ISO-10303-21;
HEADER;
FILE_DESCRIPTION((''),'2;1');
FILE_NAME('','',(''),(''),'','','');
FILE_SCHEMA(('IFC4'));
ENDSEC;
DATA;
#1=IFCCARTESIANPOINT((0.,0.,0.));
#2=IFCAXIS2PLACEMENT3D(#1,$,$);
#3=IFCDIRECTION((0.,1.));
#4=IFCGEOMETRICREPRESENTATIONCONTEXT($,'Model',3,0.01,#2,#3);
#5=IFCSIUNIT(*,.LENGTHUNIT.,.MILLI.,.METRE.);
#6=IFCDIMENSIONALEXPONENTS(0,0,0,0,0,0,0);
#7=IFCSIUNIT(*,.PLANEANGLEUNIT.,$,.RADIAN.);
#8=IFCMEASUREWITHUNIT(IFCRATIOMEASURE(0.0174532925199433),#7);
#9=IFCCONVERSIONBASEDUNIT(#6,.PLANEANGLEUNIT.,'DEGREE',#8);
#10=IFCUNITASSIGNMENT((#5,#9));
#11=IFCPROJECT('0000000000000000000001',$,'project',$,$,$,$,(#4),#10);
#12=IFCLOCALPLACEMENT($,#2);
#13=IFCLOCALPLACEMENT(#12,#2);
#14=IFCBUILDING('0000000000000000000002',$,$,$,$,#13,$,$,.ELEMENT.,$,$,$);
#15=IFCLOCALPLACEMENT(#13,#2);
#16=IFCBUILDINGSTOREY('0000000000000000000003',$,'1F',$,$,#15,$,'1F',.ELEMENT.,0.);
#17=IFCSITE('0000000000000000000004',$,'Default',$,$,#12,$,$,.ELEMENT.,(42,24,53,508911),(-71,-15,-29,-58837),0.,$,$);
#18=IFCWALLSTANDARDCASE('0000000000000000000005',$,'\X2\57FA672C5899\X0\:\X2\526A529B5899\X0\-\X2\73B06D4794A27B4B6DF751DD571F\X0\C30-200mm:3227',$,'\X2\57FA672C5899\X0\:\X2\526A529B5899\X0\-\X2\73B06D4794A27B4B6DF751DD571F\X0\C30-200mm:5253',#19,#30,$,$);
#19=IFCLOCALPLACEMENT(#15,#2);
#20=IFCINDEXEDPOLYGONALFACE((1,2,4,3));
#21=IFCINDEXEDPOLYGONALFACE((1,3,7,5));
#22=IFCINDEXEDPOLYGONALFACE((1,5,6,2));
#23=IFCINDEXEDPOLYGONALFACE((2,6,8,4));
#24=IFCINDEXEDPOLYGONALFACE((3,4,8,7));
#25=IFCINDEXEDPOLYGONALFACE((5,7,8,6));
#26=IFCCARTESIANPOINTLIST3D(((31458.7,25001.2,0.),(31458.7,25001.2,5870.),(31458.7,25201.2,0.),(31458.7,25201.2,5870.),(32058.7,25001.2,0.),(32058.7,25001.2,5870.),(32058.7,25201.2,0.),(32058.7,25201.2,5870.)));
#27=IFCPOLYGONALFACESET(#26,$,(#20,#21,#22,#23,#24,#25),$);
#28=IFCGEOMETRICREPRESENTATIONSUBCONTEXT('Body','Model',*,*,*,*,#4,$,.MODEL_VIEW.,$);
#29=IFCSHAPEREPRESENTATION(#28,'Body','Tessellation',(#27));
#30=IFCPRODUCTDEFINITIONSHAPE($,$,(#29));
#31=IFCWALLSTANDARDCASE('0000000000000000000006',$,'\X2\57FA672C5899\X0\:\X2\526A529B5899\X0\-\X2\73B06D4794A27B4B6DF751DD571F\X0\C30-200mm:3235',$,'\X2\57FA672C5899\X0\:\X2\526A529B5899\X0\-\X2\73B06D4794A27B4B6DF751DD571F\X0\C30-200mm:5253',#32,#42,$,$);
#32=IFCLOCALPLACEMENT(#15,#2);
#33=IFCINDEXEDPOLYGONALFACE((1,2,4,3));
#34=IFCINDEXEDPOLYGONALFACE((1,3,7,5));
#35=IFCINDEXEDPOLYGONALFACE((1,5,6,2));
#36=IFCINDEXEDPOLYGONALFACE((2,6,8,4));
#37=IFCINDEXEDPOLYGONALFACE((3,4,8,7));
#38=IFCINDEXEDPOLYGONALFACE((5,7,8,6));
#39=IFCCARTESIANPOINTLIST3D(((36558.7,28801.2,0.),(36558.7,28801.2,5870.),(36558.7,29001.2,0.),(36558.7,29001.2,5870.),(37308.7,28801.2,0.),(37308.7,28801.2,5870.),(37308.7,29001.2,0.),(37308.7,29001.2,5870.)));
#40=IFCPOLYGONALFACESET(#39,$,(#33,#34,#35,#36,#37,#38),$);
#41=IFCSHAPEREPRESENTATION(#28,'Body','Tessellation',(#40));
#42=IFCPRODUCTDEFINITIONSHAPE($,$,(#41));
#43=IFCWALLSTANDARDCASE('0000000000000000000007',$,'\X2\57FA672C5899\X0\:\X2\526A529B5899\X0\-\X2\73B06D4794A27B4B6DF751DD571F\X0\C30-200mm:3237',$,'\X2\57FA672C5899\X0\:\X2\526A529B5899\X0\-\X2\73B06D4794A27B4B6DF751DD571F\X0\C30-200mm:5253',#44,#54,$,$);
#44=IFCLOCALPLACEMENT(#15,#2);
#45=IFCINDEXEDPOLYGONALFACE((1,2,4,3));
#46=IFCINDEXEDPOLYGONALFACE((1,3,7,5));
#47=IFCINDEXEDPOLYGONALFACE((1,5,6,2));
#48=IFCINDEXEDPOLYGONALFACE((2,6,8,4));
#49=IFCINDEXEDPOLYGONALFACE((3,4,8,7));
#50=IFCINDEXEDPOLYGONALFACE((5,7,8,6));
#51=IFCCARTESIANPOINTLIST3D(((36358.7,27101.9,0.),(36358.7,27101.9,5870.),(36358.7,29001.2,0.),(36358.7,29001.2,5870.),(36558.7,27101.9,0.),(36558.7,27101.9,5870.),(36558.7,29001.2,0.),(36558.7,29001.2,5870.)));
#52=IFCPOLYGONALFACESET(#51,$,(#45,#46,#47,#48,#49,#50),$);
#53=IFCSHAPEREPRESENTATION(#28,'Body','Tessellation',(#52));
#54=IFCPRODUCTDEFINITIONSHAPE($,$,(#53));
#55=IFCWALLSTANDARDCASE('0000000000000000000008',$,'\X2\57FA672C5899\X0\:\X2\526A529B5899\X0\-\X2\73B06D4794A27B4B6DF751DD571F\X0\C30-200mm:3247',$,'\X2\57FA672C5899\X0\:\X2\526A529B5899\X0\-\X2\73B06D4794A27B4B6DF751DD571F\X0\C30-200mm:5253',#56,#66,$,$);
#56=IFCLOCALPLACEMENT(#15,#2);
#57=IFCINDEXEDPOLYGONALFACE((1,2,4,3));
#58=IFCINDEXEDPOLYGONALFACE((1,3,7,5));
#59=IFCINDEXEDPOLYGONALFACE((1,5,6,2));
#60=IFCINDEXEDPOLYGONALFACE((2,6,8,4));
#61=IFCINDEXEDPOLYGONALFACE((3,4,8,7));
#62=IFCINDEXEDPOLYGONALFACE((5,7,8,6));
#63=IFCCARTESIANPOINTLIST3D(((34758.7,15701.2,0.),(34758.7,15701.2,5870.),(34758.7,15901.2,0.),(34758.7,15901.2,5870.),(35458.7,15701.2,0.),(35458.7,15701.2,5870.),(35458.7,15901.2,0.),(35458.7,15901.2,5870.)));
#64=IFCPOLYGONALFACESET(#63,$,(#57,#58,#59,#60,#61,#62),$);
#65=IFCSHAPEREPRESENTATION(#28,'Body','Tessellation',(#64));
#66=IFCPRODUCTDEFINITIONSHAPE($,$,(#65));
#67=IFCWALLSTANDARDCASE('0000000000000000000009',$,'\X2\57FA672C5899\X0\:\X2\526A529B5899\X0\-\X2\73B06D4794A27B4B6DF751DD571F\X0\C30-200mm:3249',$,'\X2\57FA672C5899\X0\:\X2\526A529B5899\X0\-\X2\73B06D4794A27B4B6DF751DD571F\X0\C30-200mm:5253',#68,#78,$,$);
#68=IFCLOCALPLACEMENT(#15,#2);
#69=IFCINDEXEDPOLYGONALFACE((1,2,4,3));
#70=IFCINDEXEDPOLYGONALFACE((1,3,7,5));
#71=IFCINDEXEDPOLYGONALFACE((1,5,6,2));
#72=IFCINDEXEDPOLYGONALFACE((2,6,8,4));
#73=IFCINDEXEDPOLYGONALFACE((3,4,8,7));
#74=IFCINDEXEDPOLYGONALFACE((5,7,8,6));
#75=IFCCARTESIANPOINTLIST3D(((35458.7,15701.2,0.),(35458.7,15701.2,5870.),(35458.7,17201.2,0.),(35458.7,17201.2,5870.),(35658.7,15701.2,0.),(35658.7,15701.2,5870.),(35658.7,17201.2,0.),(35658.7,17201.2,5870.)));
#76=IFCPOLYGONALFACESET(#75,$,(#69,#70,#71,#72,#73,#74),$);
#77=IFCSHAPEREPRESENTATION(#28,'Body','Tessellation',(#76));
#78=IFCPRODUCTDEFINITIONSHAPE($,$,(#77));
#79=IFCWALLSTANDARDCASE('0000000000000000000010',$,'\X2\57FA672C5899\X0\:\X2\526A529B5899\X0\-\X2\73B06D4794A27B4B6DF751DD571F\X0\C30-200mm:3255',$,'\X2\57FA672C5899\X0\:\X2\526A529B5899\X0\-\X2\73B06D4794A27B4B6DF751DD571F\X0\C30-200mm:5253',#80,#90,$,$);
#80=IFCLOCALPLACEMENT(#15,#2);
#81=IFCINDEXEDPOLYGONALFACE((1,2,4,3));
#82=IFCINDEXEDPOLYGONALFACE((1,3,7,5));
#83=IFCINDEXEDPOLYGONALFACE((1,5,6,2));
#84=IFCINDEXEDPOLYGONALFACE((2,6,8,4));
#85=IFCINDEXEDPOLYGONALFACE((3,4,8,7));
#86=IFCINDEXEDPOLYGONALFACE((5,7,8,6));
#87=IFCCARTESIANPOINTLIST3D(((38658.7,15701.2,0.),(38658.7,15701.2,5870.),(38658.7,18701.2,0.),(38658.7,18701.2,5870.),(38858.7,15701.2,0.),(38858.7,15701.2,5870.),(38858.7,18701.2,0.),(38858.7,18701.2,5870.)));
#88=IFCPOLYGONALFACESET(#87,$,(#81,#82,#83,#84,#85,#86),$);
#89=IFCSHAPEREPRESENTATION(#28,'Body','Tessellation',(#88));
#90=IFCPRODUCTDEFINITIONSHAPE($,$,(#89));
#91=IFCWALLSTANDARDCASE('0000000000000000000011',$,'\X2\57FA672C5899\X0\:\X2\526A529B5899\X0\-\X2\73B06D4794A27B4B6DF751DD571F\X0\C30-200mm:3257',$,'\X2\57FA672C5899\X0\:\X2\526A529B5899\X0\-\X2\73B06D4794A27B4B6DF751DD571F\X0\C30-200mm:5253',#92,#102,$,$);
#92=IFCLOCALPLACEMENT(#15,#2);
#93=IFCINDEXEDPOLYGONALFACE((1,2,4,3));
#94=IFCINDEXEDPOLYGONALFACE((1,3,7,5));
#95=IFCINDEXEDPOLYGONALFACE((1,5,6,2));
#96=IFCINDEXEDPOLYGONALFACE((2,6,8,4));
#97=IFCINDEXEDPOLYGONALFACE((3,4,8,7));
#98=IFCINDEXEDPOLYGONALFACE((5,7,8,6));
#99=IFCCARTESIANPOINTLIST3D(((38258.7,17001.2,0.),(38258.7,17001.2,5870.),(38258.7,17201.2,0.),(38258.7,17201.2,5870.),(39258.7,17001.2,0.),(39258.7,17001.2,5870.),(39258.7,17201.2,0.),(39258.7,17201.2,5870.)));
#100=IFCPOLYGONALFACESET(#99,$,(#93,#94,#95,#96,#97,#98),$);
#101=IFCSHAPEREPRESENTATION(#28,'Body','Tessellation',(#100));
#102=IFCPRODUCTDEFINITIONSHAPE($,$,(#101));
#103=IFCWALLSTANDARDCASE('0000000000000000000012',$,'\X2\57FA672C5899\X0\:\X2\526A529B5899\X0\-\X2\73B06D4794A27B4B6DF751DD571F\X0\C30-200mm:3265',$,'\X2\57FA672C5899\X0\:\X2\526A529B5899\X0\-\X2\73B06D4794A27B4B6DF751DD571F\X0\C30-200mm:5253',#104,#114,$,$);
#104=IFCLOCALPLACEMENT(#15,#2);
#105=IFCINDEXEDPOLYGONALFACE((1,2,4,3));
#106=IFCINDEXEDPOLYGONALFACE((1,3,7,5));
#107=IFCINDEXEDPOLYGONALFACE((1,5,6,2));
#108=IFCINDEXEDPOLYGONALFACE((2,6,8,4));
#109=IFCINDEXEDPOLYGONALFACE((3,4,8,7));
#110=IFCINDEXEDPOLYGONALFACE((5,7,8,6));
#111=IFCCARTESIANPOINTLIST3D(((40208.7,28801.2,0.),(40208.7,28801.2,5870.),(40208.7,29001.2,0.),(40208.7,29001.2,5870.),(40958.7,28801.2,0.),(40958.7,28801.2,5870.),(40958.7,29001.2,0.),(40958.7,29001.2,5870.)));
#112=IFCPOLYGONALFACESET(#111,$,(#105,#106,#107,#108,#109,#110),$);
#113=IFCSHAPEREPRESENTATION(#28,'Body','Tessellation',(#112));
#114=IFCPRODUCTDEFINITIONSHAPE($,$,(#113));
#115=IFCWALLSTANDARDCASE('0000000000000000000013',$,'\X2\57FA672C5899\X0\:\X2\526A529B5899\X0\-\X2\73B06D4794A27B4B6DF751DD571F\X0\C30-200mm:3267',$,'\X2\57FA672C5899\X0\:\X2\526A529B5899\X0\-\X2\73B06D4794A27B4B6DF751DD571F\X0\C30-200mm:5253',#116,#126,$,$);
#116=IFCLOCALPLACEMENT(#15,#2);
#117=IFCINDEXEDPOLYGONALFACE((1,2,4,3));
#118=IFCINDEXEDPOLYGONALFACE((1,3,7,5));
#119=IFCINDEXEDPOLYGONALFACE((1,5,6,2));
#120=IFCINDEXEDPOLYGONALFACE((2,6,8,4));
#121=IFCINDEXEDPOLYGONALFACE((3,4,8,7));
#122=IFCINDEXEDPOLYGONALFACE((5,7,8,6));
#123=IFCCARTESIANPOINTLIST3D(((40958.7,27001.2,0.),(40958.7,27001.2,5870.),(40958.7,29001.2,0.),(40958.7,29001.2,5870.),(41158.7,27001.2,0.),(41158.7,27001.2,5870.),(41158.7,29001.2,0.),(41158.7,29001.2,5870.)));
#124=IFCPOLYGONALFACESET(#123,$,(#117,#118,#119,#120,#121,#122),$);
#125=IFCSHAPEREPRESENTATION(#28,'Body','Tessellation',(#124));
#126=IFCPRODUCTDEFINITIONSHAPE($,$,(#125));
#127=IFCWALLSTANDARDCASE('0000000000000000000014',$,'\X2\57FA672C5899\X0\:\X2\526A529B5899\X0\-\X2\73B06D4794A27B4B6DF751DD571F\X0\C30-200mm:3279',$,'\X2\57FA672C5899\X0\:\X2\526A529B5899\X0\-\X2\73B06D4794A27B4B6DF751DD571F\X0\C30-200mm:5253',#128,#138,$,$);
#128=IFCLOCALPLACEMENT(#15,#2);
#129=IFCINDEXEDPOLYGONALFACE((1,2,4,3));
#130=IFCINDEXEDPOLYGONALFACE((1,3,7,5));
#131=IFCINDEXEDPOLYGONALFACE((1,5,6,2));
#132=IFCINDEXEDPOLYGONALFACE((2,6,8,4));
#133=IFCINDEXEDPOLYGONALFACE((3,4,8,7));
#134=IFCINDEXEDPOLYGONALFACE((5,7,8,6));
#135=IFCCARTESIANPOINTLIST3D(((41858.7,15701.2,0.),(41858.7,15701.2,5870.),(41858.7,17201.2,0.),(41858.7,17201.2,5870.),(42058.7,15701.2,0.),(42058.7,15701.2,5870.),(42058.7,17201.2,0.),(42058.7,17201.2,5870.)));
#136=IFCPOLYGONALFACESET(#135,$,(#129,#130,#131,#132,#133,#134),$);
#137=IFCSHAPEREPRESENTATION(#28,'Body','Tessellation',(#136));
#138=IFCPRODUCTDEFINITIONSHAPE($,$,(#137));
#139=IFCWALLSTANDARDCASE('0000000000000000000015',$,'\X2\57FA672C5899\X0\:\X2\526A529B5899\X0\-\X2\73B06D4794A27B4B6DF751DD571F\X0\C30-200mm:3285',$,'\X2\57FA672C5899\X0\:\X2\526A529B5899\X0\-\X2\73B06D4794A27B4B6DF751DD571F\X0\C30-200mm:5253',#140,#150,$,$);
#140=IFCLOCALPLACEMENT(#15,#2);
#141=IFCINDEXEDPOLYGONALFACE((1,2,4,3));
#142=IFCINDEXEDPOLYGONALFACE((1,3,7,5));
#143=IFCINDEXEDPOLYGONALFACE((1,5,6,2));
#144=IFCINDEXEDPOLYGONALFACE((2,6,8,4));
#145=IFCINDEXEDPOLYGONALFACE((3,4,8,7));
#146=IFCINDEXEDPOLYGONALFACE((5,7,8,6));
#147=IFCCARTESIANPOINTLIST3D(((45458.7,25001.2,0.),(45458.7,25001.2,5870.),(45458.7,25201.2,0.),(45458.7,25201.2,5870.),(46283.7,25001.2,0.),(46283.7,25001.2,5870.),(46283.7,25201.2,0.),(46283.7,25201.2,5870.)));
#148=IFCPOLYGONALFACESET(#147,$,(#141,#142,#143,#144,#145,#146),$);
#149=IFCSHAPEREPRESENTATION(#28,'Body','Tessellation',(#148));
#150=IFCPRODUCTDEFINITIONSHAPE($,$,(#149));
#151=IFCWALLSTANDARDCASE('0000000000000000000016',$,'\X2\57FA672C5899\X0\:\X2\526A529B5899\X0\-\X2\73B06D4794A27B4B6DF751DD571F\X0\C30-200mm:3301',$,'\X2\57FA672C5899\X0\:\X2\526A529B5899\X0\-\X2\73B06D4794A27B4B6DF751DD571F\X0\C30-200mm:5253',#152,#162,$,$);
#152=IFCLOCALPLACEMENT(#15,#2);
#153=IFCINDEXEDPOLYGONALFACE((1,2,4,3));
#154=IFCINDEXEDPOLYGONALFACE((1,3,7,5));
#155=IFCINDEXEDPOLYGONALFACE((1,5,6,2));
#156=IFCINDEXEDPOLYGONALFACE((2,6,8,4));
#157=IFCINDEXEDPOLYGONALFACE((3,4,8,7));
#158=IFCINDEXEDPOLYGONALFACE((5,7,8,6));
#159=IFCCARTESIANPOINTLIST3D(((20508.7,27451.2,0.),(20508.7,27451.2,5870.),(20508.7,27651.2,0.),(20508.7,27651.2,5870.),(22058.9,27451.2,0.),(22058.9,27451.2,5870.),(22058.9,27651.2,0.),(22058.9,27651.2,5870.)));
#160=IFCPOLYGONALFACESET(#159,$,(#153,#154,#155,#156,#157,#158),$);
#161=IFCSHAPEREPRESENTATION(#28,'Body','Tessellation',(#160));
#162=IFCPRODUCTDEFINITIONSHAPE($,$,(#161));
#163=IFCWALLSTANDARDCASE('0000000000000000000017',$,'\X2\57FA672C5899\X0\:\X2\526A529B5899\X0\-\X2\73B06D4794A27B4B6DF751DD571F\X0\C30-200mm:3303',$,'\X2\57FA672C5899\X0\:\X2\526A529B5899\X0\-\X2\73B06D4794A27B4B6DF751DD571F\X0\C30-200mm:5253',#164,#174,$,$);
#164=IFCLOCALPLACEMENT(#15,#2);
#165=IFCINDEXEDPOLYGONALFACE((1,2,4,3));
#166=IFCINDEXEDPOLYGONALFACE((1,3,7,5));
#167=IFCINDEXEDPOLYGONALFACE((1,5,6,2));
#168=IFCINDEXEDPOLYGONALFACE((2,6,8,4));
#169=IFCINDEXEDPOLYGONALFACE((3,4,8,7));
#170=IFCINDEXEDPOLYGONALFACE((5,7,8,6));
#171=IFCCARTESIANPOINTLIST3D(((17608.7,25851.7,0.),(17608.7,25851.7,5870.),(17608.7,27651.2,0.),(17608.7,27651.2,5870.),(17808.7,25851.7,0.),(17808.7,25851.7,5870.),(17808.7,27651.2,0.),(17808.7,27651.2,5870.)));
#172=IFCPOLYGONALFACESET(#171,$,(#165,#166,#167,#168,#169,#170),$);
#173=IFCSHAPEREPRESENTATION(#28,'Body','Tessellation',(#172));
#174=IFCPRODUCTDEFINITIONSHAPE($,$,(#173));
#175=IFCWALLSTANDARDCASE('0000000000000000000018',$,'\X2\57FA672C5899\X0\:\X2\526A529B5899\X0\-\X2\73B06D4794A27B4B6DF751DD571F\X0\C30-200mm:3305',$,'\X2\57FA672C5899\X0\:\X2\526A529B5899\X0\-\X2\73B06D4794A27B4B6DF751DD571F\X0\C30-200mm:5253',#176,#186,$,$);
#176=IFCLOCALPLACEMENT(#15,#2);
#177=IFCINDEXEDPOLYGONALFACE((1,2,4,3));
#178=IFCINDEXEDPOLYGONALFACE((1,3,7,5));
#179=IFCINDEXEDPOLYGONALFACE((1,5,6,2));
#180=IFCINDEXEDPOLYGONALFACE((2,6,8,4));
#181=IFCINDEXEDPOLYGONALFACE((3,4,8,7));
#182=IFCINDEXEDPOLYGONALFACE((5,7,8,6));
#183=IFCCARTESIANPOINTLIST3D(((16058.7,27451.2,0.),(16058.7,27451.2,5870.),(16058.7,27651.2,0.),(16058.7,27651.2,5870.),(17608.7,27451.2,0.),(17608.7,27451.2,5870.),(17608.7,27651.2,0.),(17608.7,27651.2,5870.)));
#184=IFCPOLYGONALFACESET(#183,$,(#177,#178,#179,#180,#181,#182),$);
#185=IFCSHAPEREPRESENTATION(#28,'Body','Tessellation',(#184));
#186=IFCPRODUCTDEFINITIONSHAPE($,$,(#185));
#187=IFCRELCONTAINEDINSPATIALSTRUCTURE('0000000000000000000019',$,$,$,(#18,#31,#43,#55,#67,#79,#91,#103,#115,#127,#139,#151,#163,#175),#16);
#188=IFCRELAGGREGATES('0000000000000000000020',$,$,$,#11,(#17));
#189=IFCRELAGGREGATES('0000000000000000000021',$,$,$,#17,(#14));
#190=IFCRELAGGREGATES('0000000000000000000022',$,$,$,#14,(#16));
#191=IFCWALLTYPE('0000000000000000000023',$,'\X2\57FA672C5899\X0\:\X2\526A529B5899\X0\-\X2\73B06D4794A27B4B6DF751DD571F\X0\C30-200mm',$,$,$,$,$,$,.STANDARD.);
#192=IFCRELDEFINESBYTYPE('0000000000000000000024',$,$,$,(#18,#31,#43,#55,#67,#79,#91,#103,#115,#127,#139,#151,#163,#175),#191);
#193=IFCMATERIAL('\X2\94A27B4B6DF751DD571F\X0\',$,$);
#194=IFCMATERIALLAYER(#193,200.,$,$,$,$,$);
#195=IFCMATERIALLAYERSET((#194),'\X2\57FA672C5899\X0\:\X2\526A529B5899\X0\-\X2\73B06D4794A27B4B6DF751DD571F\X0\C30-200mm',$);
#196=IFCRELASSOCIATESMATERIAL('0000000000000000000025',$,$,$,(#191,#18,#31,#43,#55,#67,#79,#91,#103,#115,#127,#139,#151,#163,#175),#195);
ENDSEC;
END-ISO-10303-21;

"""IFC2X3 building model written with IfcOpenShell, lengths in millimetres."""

from ifc_helpers import new_model, entity, si_unit, converted_unit, direction, frame, frame_2d, origin, place, context, subcontext, project, spatial, rectangle, extrude, material, layer, layer_set, layer_usage, type_object, element, save


model = new_model("IFC2X3")

# Units and contexts
model_context = context("Model", 3, precision=0.01, world=origin(), true_north=direction((0.0, 1.0)))
body_context = subcontext(model_context, "Body", "Model", "MODEL_VIEW")
ifc_project = project(units=[si_unit("LENGTHUNIT", "METRE", prefix="MILLI"), converted_unit("PLANEANGLEUNIT", "DEGREE", entity("IfcRatioMeasure", 0.0174532925199433), si_unit("PLANEANGLEUNIT", "RADIAN"), dimensions=[0, 0, 0, 0, 0, 0, 0])], contexts=[model_context])

# Site, building, storey
site_placement = place(None, origin())
site = spatial("IfcSite", under=ifc_project, at=site_placement, Name="Default", CompositionType="ELEMENT", RefLatitude=(42, 24, 53, 508911), RefLongitude=(-71, -15, -29, -58837), RefElevation=0.0)
building_placement = place(site_placement, origin())
building = spatial("IfcBuilding", under=site, at=building_placement, CompositionType="ELEMENT")
storey_placement = place(building_placement, origin())
storey = spatial("IfcBuildingStorey", under=building, at=storey_placement, Name="1F", LongName="1F", CompositionType="ELEMENT", Elevation=0.0)

# Walls
ifc_material = material(Name="钢筋混凝土")
ifc_layer_1 = layer(ifc_material, 200.0)
ifc_layer_set_1 = layer_set([ifc_layer_1], Name="基本墙:剪力墙-现浇钢筋混凝土C30-200mm")
wall_type_1 = type_object("IfcWallType", Name="基本墙:剪力墙-现浇钢筋混凝土C30-200mm", PredefinedType="STANDARD", material=ifc_layer_set_1)
ifc_layer_usage_1 = layer_usage(ifc_layer_set_1, "AXIS2", "NEGATIVE", 100.0)
wall_1_placement = place(storey_placement, frame((31458.7, 25101.2, 0.0)))
element("IfcWallStandardCase", 1, at=wall_1_placement, inside=storey, type_object=wall_type_1, material=ifc_layer_usage_1, Name="基本墙:剪力墙-现浇钢筋混凝土C30-200mm:3227", ObjectType="基本墙:剪力墙-现浇钢筋混凝土C30-200mm:5253", context=body_context, shape_type="SweptSolid", body=[
    extrude(rectangle(XDim=600.0, YDim=200.0, at=frame_2d((300.0, 0.0), x_axis=(-1.0, 0.0))), origin(), (0.0, 0.0, 1.0), 5870.0),
])
ifc_layer_usage_2 = layer_usage(ifc_layer_set_1, "AXIS2", "NEGATIVE", 100.0)
wall_2_placement = place(storey_placement, frame((37308.7, 28901.2, 0.0), z_axis=(0.0, 0.0, 1.0), x_axis=(-1.0, 0.0, 0.0)))
element("IfcWallStandardCase", 2, at=wall_2_placement, inside=storey, type_object=wall_type_1, material=ifc_layer_usage_2, Name="基本墙:剪力墙-现浇钢筋混凝土C30-200mm:3235", ObjectType="基本墙:剪力墙-现浇钢筋混凝土C30-200mm:5253", context=body_context, shape_type="SweptSolid", body=[
    extrude(rectangle(XDim=750.0, YDim=200.0, at=frame_2d((375.0, 0.0), x_axis=(-1.0, 0.0))), origin(), (0.0, 0.0, 1.0), 5870.0),
])
ifc_layer_usage_3 = layer_usage(ifc_layer_set_1, "AXIS2", "NEGATIVE", 100.0)
wall_3_placement = place(storey_placement, frame((36458.7, 29001.2, 0.0), z_axis=(0.0, 0.0, 1.0), x_axis=(0.0, -1.0, 0.0)))
element("IfcWallStandardCase", 3, at=wall_3_placement, inside=storey, type_object=wall_type_1, material=ifc_layer_usage_3, Name="基本墙:剪力墙-现浇钢筋混凝土C30-200mm:3237", ObjectType="基本墙:剪力墙-现浇钢筋混凝土C30-200mm:5253", context=body_context, shape_type="SweptSolid", body=[
    extrude(rectangle(XDim=1899.3, YDim=200.0, at=frame_2d((949.7, 0.0), x_axis=(-1.0, 0.0))), origin(), (0.0, 0.0, 1.0), 5870.0),
])
ifc_layer_usage_4 = layer_usage(ifc_layer_set_1, "AXIS2", "NEGATIVE", 100.0)
wall_4_placement = place(storey_placement, frame((34758.7, 15801.2, 0.0)))
element("IfcWallStandardCase", 4, at=wall_4_placement, inside=storey, type_object=wall_type_1, material=ifc_layer_usage_4, Name="基本墙:剪力墙-现浇钢筋混凝土C30-200mm:3247", ObjectType="基本墙:剪力墙-现浇钢筋混凝土C30-200mm:5253", context=body_context, shape_type="SweptSolid", body=[
    extrude(rectangle(XDim=700.0, YDim=200.0, at=frame_2d((350.0, 0.0), x_axis=(-1.0, 0.0))), origin(), (0.0, 0.0, 1.0), 5870.0),
])
ifc_layer_usage_5 = layer_usage(ifc_layer_set_1, "AXIS2", "NEGATIVE", 100.0)
wall_5_placement = place(storey_placement, frame((35558.7, 15701.2, 0.0), z_axis=(0.0, 0.0, 1.0), x_axis=(0.0, 1.0, 0.0)))
element("IfcWallStandardCase", 5, at=wall_5_placement, inside=storey, type_object=wall_type_1, material=ifc_layer_usage_5, Name="基本墙:剪力墙-现浇钢筋混凝土C30-200mm:3249", ObjectType="基本墙:剪力墙-现浇钢筋混凝土C30-200mm:5253", context=body_context, shape_type="SweptSolid", body=[
    extrude(rectangle(XDim=1500.0, YDim=200.0, at=frame_2d((750.0, 0.0), x_axis=(-1.0, 0.0))), origin(), (0.0, 0.0, 1.0), 5870.0),
])
ifc_layer_usage_6 = layer_usage(ifc_layer_set_1, "AXIS2", "NEGATIVE", 100.0)
wall_6_placement = place(storey_placement, frame((38758.7, 15701.2, 0.0), z_axis=(0.0, 0.0, 1.0), x_axis=(0.0, 1.0, 0.0)))
element("IfcWallStandardCase", 6, at=wall_6_placement, inside=storey, type_object=wall_type_1, material=ifc_layer_usage_6, Name="基本墙:剪力墙-现浇钢筋混凝土C30-200mm:3255", ObjectType="基本墙:剪力墙-现浇钢筋混凝土C30-200mm:5253", context=body_context, shape_type="SweptSolid", body=[
    extrude(rectangle(XDim=3000.0, YDim=200.0, at=frame_2d((1500.0, 0.0), x_axis=(-1.0, 0.0))), origin(), (0.0, 0.0, 1.0), 5870.0),
])
ifc_layer_usage_7 = layer_usage(ifc_layer_set_1, "AXIS2", "NEGATIVE", 100.0)
wall_7_placement = place(storey_placement, frame((38258.7, 17101.2, 0.0)))
element("IfcWallStandardCase", 7, at=wall_7_placement, inside=storey, type_object=wall_type_1, material=ifc_layer_usage_7, Name="基本墙:剪力墙-现浇钢筋混凝土C30-200mm:3257", ObjectType="基本墙:剪力墙-现浇钢筋混凝土C30-200mm:5253", context=body_context, shape_type="SweptSolid", body=[
    extrude(rectangle(XDim=1000.1, YDim=200.0, at=frame_2d((500.0, 0.0), x_axis=(-1.0, 0.0))), origin(), (0.0, 0.0, 1.0), 5870.0),
])
ifc_layer_usage_8 = layer_usage(ifc_layer_set_1, "AXIS2", "POSITIVE", -100.0)
wall_8_placement = place(storey_placement, frame((40208.7, 28901.2, 0.0)))
element("IfcWallStandardCase", 8, at=wall_8_placement, inside=storey, type_object=wall_type_1, material=ifc_layer_usage_8, Name="基本墙:剪力墙-现浇钢筋混凝土C30-200mm:3265", ObjectType="基本墙:剪力墙-现浇钢筋混凝土C30-200mm:5253", context=body_context, shape_type="SweptSolid", body=[
    extrude(rectangle(XDim=750.0, YDim=200.0, at=frame_2d((375.0, 0.0), x_axis=(-1.0, 0.0))), origin(), (0.0, 0.0, 1.0), 5870.0),
])
ifc_layer_usage_9 = layer_usage(ifc_layer_set_1, "AXIS2", "POSITIVE", -100.0)
wall_9_placement = place(storey_placement, frame((41058.7, 29001.2, 0.0), z_axis=(0.0, 0.0, 1.0), x_axis=(0.0, -1.0, 0.0)))
element("IfcWallStandardCase", 9, at=wall_9_placement, inside=storey, type_object=wall_type_1, material=ifc_layer_usage_9, Name="基本墙:剪力墙-现浇钢筋混凝土C30-200mm:3267", ObjectType="基本墙:剪力墙-现浇钢筋混凝土C30-200mm:5253", context=body_context, shape_type="SweptSolid", body=[
    extrude(rectangle(XDim=2000.0, YDim=200.0, at=frame_2d((1000.0, 0.0), x_axis=(-1.0, 0.0))), origin(), (0.0, 0.0, 1.0), 5870.0),
])
ifc_layer_usage_10 = layer_usage(ifc_layer_set_1, "AXIS2", "POSITIVE", -100.0)
wall_10_placement = place(storey_placement, frame((41958.7, 15701.2, 0.0), z_axis=(0.0, 0.0, 1.0), x_axis=(0.0, 1.0, 0.0)))
element("IfcWallStandardCase", 10, at=wall_10_placement, inside=storey, type_object=wall_type_1, material=ifc_layer_usage_10, Name="基本墙:剪力墙-现浇钢筋混凝土C30-200mm:3279", ObjectType="基本墙:剪力墙-现浇钢筋混凝土C30-200mm:5253", context=body_context, shape_type="SweptSolid", body=[
    extrude(rectangle(XDim=1500.0, YDim=200.0, at=frame_2d((750.0, 0.0), x_axis=(-1.0, 0.0))), origin(), (0.0, 0.0, 1.0), 5870.0),
])
ifc_layer_usage_11 = layer_usage(ifc_layer_set_1, "AXIS2", "NEGATIVE", 100.0)
wall_11_placement = place(storey_placement, frame((45458.7, 25101.2, 0.0)))
element("IfcWallStandardCase", 11, at=wall_11_placement, inside=storey, type_object=wall_type_1, material=ifc_layer_usage_11, Name="基本墙:剪力墙-现浇钢筋混凝土C30-200mm:3285", ObjectType="基本墙:剪力墙-现浇钢筋混凝土C30-200mm:5253", context=body_context, shape_type="SweptSolid", body=[
    extrude(rectangle(XDim=825.0, YDim=200.0, at=frame_2d((412.5, 0.0), x_axis=(-1.0, 0.0))), origin(), (0.0, 0.0, 1.0), 5870.0),
])
ifc_layer_usage_12 = layer_usage(ifc_layer_set_1, "AXIS2", "NEGATIVE", 100.0)
wall_12_placement = place(storey_placement, frame((20508.7, 27551.2, 0.0)))
element("IfcWallStandardCase", 12, at=wall_12_placement, inside=storey, type_object=wall_type_1, material=ifc_layer_usage_12, Name="基本墙:剪力墙-现浇钢筋混凝土C30-200mm:3301", ObjectType="基本墙:剪力墙-现浇钢筋混凝土C30-200mm:5253", context=body_context, shape_type="SweptSolid", body=[
    extrude(rectangle(XDim=1550.2, YDim=200.0, at=frame_2d((775.1, 0.0), x_axis=(-1.0, 0.0))), origin(), (0.0, 0.0, 1.0), 5870.0),
])
ifc_layer_usage_13 = layer_usage(ifc_layer_set_1, "AXIS2", "POSITIVE", -100.0)
wall_13_placement = place(storey_placement, frame((17708.7, 25851.7, 0.0), z_axis=(0.0, 0.0, 1.0), x_axis=(0.0, 1.0, 0.0)))
element("IfcWallStandardCase", 13, at=wall_13_placement, inside=storey, type_object=wall_type_1, material=ifc_layer_usage_13, Name="基本墙:剪力墙-现浇钢筋混凝土C30-200mm:3303", ObjectType="基本墙:剪力墙-现浇钢筋混凝土C30-200mm:5253", context=body_context, shape_type="SweptSolid", body=[
    extrude(rectangle(XDim=1799.5, YDim=200.0, at=frame_2d((899.7, 0.0), x_axis=(-1.0, 0.0))), origin(), (0.0, 0.0, 1.0), 5870.0),
])
ifc_layer_usage_14 = layer_usage(ifc_layer_set_1, "AXIS2", "POSITIVE", -100.0)
wall_14_placement = place(storey_placement, frame((17608.7, 27551.2, 0.0), z_axis=(0.0, 0.0, 1.0), x_axis=(-1.0, 0.0, 0.0)))
element("IfcWallStandardCase", 14, at=wall_14_placement, inside=storey, type_object=wall_type_1, material=ifc_layer_usage_14, Name="基本墙:剪力墙-现浇钢筋混凝土C30-200mm:3305", ObjectType="基本墙:剪力墙-现浇钢筋混凝土C30-200mm:5253", context=body_context, shape_type="SweptSolid", body=[
    extrude(rectangle(XDim=1550.0, YDim=200.0, at=frame_2d((775.0, 0.0), x_axis=(-1.0, 0.0))), origin(), (0.0, 0.0, 1.0), 5870.0),
])

save(model, "model.ifc")
